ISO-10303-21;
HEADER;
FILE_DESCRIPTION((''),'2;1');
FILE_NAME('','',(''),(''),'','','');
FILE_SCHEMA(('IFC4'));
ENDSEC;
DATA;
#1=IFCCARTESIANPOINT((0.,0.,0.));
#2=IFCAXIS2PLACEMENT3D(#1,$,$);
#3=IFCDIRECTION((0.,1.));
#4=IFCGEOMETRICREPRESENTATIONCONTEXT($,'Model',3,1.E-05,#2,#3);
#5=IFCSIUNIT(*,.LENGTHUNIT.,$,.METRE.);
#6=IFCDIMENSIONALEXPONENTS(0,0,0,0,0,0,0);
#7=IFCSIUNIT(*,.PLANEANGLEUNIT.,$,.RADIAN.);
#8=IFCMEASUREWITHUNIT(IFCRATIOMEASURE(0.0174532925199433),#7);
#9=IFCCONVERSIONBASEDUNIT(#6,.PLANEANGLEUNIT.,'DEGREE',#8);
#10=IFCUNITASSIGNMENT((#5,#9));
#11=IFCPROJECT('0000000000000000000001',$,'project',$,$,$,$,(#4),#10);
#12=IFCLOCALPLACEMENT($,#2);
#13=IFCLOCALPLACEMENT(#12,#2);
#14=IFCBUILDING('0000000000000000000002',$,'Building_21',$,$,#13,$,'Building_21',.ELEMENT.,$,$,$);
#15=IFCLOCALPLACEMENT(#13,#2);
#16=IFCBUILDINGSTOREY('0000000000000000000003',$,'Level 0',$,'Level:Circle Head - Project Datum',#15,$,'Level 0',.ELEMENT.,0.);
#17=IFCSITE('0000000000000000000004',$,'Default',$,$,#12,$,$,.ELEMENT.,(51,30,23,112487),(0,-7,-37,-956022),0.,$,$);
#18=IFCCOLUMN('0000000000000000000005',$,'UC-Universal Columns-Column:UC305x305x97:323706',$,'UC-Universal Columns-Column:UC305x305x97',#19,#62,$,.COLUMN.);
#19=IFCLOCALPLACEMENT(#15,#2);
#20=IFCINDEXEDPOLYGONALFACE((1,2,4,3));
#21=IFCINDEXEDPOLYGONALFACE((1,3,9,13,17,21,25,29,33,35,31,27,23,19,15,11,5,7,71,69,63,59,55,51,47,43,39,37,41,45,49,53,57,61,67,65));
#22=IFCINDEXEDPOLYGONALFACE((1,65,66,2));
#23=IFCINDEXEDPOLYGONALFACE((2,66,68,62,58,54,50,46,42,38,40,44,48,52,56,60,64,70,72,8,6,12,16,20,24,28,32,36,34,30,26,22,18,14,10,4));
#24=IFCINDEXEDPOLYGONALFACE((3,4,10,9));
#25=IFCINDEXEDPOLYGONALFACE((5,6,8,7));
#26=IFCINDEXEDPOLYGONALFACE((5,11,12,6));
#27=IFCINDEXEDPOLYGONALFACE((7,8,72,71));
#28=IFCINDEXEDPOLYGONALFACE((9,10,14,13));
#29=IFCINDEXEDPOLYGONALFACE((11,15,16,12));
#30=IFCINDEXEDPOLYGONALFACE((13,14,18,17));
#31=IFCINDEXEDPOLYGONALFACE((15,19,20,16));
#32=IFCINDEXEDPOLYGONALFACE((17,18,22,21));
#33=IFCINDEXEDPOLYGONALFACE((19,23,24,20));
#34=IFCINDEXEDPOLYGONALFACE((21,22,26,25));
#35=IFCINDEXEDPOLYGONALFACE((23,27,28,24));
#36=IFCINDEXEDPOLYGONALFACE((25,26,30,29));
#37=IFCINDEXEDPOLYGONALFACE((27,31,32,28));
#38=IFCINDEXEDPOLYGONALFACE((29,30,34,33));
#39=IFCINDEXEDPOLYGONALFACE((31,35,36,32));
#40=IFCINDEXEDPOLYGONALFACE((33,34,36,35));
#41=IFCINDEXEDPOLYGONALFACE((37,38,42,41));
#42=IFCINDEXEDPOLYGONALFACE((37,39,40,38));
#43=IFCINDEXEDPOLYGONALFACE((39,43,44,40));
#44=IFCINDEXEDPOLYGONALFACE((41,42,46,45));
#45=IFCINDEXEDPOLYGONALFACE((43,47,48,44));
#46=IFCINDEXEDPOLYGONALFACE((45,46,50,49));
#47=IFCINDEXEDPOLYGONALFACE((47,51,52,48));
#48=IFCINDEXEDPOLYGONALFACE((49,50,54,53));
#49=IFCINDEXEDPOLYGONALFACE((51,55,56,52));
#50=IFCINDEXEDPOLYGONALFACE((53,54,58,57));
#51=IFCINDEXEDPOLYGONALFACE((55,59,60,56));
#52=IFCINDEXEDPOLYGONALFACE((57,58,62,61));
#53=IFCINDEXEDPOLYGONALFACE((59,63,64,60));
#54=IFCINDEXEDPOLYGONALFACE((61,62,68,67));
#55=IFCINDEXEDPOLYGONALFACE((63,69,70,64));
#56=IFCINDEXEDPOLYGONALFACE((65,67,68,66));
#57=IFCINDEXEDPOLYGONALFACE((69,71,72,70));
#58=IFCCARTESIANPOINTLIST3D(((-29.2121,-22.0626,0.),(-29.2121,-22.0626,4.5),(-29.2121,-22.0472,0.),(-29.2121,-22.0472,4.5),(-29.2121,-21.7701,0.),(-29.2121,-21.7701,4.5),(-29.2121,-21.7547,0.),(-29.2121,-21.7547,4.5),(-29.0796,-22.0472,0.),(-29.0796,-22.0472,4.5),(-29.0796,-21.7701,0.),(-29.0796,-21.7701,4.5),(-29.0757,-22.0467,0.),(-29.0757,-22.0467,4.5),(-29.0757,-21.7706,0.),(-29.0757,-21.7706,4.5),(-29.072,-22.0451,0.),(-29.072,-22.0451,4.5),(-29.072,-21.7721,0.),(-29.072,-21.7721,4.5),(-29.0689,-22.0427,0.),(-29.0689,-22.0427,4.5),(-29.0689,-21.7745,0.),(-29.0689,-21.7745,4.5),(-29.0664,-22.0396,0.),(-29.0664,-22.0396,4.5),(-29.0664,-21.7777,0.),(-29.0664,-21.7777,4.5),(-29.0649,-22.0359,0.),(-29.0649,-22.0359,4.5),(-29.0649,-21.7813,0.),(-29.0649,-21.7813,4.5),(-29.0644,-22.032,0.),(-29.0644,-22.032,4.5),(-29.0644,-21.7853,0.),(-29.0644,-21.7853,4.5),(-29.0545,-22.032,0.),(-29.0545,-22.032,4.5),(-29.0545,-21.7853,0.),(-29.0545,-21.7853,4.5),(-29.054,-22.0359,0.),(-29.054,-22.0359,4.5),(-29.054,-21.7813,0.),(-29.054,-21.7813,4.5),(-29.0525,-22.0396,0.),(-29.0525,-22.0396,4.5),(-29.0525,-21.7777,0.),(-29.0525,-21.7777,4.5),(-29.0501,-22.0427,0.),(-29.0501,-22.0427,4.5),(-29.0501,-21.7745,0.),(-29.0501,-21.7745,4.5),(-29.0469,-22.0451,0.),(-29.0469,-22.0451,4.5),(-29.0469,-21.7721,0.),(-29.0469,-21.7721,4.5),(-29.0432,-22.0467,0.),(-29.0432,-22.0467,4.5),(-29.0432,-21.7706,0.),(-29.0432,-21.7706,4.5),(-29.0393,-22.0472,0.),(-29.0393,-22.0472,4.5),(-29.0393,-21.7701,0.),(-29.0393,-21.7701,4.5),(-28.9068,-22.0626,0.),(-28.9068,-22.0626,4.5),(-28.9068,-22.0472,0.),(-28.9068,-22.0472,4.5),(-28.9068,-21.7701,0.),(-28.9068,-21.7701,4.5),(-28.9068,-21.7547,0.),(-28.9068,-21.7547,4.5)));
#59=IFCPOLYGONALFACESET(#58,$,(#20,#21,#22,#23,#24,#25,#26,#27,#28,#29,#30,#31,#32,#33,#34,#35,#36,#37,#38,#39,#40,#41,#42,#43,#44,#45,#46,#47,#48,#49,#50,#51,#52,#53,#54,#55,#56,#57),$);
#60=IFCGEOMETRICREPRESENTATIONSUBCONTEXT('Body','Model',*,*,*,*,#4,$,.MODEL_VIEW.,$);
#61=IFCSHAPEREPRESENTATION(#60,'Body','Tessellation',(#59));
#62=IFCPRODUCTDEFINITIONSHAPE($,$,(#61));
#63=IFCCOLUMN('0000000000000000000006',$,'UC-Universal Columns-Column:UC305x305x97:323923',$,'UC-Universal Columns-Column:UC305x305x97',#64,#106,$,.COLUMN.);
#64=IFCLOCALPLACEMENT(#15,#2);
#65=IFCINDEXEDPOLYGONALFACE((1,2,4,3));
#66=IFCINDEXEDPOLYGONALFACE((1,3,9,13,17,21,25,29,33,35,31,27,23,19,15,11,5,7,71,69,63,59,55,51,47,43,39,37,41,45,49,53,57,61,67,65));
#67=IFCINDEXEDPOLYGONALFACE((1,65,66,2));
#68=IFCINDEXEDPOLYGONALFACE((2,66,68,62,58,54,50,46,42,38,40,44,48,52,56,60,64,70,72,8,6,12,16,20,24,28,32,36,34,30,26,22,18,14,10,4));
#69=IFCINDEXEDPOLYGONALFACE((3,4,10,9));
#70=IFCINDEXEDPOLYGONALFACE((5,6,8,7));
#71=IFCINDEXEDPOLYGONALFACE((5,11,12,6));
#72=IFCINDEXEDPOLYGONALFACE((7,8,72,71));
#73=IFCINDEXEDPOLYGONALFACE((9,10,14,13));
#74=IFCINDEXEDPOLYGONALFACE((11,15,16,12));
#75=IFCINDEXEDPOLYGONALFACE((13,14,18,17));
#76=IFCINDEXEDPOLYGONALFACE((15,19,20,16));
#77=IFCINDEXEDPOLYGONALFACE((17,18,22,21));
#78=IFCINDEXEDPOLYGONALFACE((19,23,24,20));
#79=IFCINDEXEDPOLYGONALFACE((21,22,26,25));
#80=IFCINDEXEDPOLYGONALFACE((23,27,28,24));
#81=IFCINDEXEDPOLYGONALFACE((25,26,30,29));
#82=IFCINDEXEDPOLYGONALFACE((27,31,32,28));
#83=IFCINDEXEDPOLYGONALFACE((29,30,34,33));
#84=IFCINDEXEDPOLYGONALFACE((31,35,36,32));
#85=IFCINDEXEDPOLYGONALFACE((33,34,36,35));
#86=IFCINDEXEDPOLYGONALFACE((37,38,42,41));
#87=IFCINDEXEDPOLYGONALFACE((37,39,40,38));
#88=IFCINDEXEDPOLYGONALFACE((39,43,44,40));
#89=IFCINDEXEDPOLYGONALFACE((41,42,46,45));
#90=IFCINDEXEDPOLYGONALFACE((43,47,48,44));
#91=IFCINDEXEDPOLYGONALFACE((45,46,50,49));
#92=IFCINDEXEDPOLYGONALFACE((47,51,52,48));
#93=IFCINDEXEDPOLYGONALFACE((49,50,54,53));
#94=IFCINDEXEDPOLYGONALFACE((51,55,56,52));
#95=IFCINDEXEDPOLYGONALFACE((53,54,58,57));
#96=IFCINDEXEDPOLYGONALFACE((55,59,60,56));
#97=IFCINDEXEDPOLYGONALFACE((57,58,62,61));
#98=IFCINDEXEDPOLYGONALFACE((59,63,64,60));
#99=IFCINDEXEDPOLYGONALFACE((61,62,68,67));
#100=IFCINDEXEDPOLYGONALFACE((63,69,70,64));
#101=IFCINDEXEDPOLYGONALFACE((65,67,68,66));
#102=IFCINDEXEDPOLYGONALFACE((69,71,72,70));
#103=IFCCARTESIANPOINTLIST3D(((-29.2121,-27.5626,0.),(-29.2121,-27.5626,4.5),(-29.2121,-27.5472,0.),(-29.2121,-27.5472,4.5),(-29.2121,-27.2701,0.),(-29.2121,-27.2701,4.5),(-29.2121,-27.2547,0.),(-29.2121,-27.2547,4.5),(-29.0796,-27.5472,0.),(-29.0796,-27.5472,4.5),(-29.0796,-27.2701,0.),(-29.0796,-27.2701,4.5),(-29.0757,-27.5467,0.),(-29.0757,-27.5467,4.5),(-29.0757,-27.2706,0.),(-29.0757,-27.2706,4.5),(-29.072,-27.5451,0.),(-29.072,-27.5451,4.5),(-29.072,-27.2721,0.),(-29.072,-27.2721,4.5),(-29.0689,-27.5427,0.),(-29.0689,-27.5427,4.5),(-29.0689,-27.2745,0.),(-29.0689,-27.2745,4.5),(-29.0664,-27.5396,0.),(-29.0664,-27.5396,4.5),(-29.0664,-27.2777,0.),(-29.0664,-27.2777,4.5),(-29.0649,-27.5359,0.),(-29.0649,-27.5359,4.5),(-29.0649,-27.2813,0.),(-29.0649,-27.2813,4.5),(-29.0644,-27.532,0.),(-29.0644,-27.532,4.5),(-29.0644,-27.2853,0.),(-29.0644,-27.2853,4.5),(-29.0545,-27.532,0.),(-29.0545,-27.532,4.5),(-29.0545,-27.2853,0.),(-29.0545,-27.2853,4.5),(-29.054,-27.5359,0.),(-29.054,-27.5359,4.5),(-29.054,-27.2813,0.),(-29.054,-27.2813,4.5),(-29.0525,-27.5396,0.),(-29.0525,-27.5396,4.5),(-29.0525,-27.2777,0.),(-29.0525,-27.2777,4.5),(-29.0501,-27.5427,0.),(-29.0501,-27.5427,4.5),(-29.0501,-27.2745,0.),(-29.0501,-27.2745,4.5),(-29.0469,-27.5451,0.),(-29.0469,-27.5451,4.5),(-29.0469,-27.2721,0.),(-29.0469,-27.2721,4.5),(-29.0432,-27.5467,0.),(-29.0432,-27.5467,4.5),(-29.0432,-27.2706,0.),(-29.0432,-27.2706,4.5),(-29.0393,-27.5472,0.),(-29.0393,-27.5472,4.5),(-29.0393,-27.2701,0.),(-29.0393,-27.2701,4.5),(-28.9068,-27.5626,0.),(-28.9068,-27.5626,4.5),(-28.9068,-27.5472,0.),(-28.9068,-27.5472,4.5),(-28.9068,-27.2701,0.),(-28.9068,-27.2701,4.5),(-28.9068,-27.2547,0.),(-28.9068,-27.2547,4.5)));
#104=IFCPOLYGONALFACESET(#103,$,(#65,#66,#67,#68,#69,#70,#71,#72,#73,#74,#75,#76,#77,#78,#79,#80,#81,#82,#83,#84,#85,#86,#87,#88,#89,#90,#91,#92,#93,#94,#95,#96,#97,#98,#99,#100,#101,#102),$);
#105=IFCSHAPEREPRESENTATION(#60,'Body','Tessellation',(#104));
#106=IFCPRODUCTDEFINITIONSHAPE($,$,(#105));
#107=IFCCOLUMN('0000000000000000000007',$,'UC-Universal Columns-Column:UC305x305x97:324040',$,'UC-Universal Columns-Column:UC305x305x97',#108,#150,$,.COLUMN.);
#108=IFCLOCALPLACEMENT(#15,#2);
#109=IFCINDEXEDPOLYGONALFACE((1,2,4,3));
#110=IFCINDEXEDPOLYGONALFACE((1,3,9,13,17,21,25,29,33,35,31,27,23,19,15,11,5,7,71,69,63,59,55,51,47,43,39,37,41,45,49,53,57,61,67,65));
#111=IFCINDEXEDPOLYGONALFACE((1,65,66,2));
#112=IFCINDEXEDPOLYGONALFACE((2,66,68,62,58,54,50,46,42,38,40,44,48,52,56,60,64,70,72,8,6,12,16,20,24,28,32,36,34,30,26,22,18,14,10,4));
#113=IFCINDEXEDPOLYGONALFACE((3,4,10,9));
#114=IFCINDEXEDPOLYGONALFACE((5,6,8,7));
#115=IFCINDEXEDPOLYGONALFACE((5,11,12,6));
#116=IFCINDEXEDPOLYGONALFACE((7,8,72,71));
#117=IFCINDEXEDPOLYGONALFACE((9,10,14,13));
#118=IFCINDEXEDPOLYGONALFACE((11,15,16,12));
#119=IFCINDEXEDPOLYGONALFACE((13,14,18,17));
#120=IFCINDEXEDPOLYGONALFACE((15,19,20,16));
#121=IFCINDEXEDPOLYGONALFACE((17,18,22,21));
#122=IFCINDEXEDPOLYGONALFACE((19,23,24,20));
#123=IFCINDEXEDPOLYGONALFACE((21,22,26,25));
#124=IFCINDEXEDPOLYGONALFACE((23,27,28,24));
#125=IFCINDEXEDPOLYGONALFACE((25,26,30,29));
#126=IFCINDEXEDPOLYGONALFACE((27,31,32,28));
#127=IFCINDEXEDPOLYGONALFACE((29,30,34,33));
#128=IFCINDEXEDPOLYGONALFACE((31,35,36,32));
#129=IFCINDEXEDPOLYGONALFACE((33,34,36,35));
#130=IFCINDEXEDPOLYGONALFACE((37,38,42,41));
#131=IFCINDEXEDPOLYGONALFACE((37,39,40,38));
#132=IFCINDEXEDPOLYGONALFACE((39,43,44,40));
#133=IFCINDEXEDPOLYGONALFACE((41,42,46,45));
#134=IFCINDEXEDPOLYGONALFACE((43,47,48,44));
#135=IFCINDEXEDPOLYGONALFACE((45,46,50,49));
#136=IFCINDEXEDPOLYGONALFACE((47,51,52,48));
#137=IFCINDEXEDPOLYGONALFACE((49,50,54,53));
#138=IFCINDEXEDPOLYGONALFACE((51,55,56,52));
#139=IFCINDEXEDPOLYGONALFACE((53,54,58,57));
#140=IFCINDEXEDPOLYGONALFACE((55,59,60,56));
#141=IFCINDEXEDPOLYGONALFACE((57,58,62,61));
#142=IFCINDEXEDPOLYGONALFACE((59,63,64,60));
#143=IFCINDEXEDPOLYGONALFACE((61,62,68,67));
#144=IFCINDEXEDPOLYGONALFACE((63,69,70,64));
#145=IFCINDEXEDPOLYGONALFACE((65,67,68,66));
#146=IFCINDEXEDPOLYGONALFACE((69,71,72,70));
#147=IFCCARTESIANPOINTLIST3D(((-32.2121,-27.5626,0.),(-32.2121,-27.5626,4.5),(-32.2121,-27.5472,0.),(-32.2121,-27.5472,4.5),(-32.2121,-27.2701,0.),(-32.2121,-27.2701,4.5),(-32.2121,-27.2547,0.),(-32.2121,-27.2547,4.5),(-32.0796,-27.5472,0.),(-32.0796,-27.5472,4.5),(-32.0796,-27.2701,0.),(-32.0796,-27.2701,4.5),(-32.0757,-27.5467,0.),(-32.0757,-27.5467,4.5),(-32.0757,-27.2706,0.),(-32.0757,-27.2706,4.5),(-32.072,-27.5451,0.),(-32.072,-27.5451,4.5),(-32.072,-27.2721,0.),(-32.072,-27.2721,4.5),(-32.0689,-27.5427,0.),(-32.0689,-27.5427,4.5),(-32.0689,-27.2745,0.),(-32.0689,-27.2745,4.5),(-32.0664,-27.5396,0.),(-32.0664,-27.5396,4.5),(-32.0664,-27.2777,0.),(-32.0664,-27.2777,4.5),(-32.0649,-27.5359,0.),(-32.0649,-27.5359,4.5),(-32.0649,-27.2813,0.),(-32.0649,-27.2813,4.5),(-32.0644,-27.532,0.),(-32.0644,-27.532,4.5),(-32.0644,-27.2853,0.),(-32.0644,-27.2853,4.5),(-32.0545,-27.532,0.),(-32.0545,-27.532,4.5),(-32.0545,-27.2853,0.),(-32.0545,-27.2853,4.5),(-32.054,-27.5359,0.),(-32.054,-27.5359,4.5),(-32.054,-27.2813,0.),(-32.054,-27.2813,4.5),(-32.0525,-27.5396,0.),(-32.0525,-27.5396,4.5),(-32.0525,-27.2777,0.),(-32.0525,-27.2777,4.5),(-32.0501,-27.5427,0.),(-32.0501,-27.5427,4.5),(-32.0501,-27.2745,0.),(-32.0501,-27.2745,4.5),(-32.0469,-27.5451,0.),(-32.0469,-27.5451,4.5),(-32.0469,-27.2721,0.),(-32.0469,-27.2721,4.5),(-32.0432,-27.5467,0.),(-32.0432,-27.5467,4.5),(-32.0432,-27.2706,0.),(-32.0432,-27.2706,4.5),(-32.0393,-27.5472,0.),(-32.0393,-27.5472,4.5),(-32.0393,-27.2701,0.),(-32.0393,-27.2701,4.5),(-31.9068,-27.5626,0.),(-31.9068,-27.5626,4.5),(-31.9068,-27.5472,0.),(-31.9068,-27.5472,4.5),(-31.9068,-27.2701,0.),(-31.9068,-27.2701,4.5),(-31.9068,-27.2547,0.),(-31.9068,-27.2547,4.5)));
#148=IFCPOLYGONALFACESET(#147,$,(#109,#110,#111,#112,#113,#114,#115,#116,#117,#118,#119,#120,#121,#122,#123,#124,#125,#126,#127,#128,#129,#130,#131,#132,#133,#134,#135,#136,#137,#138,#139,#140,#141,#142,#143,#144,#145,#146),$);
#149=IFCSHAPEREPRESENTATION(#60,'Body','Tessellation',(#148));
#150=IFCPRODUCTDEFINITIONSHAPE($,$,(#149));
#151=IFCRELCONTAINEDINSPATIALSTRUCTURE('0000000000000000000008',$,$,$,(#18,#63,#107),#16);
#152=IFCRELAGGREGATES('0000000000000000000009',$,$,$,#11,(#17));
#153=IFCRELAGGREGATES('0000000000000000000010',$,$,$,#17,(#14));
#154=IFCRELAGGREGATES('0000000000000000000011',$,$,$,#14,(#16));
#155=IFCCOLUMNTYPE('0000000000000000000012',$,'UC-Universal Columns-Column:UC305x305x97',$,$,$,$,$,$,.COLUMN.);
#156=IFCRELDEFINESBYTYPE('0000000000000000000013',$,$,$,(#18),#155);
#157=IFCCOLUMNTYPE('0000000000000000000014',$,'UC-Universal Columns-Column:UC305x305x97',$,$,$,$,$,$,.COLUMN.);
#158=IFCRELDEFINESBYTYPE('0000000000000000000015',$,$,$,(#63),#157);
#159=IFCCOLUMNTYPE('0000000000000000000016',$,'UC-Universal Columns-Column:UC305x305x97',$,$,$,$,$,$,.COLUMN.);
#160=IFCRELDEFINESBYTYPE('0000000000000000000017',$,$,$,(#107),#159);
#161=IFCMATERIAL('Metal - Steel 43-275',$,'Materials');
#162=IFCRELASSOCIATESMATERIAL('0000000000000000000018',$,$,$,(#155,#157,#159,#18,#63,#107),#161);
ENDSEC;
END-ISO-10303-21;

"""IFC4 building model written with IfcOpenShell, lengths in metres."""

from ifc_helpers import new_model, entity, si_unit, converted_unit, direction, frame, frame_2d, origin, place, context, subcontext, project, spatial, polyline, circle_curve, parameter, trimmed, segment, composite_curve, i_section, outline, extrude, source, transform, mapped, material, material_profile, profile_set, profile_usage, type_object, type_shapes, element, save


model = new_model("IFC4")

# Units and contexts
model_context = context("Model", 3, precision=1e-05, world=origin(), true_north=direction((0.0, 1.0)))
body_context = subcontext(model_context, "Body", "Model", "MODEL_VIEW")
ifc_project = project(units=[si_unit("LENGTHUNIT", "METRE"), converted_unit("PLANEANGLEUNIT", "DEGREE", entity("IfcRatioMeasure", 0.0174532925199433), si_unit("PLANEANGLEUNIT", "RADIAN"), dimensions=[0, 0, 0, 0, 0, 0, 0])], contexts=[model_context])

# Site, building, storey
site_placement = place(None, origin())
site = spatial("IfcSite", under=ifc_project, at=site_placement, Name="Default", CompositionType="ELEMENT", RefLatitude=(51, 30, 23, 112487), RefLongitude=(0, -7, -37, -956022), RefElevation=0.0)
building_placement = place(site_placement, origin())
building = spatial("IfcBuilding", under=site, at=building_placement, Name="Building_21", LongName="Building_21", CompositionType="ELEMENT")
storey_placement = place(building_placement, origin())
storey = spatial("IfcBuildingStorey", under=building, at=storey_placement, Name="Level 0", ObjectType="Level:Circle Head - Project Datum", LongName="Level 0", CompositionType="ELEMENT", Elevation=0.0)

# Columns
ifc_material_1 = material(Name="Metal - Steel 43-275", Category="Materials")
ifc_material_profile_1 = material_profile(ifc_material_1, outline(composite_curve([segment(polyline([(-0.1527, 0.154, 0.0), (0.1527, 0.154, 0.0)]), True, "CONTINUOUS"), segment(polyline([(0.1527, 0.154, 0.0), (0.1527, 0.1386, 0.0)]), True, "CONTINUOUS"), segment(polyline([(0.1527, 0.1386, 0.0), (0.0201, 0.1386, 0.0)]), True, "CONTINUOUS"), segment(trimmed(circle_curve(frame((0.0201, 0.1234, 0.0)), 0.0152), [parameter(90.0)], [parameter(180.0)], True, "PARAMETER"), True, "CONTINUOUS"), segment(polyline([(0.0049, 0.1234, 0.0), (0.0049, -0.1234, 0.0)]), True, "CONTINUOUS"), segment(trimmed(circle_curve(frame((0.0201, -0.1234, 0.0)), 0.0152), [parameter(180.0)], [parameter(270.0)], True, "PARAMETER"), True, "CONTINUOUS"), segment(polyline([(0.0201, -0.1386, 0.0), (0.1527, -0.1386, 0.0)]), True, "CONTINUOUS"), segment(polyline([(0.1527, -0.1386, 0.0), (0.1527, -0.154, 0.0)]), True, "CONTINUOUS"), segment(polyline([(0.1527, -0.154, 0.0), (-0.1527, -0.154, 0.0)]), True, "CONTINUOUS"), segment(polyline([(-0.1527, -0.154, 0.0), (-0.1527, -0.1386, 0.0)]), True, "CONTINUOUS"), segment(polyline([(-0.1527, -0.1386, 0.0), (-0.0201, -0.1386, 0.0)]), True, "CONTINUOUS"), segment(trimmed(circle_curve(frame((-0.0201, -0.1234, 0.0)), 0.0152), [parameter(270.0)], [parameter(0.0)], True, "PARAMETER"), True, "CONTINUOUS"), segment(polyline([(-0.0049, -0.1234, 0.0), (-0.005, 0.1234, 0.0)]), True, "CONTINUOUS"), segment(trimmed(circle_curve(frame((-0.0201, 0.1234, 0.0)), 0.0152), [parameter(0.0)], [parameter(90.0)], True, "PARAMETER"), True, "CONTINUOUS"), segment(polyline([(-0.0201, 0.1386, 0.0), (-0.1527, 0.1386, 0.0)]), True, "CONTINUOUS"), segment(polyline([(-0.1527, 0.1386, 0.0), (-0.1527, 0.154, 0.0)]), True, "CONTINUOUS")], self_intersect=False), kind="CURVE"), Name="UC305x305x97")
ifc_material_profile_2 = material_profile(ifc_material_1, outline(composite_curve([segment(polyline([(0.1527, 0.154, 0.0), (0.1527, 0.1386, 0.0)]), True, "CONTINUOUS"), segment(polyline([(0.1527, 0.1386, 0.0), (0.0049, 0.1386, 0.0)]), True, "CONTINUOUS"), segment(polyline([(0.0049, 0.1386, 0.0), (0.0049, -0.1386, 0.0)]), True, "CONTINUOUS"), segment(polyline([(0.0049, -0.1386, 0.0), (0.1527, -0.1386, 0.0)]), True, "CONTINUOUS"), segment(polyline([(0.1527, -0.1386, 0.0), (0.1527, -0.154, 0.0)]), True, "CONTINUOUS"), segment(polyline([(0.1527, -0.154, 0.0), (-0.1527, -0.154, 0.0)]), True, "CONTINUOUS"), segment(polyline([(-0.1527, -0.154, 0.0), (-0.1527, -0.1386, 0.0)]), True, "CONTINUOUS"), segment(polyline([(-0.1527, -0.1386, 0.0), (-0.005, -0.1386, 0.0)]), True, "CONTINUOUS"), segment(polyline([(-0.005, -0.1386, 0.0), (-0.005, 0.1386, 0.0)]), True, "CONTINUOUS"), segment(polyline([(-0.005, 0.1386, 0.0), (-0.1527, 0.1386, 0.0)]), True, "CONTINUOUS"), segment(polyline([(-0.1527, 0.1386, 0.0), (-0.1527, 0.154, 0.0)]), True, "CONTINUOUS"), segment(polyline([(-0.1527, 0.154, 0.0), (0.1527, 0.154, 0.0)]), True, "CONTINUOUS")], self_intersect=False), kind="CURVE"), Name="UC305x305x97")
ifc_profile_set = profile_set([ifc_material_profile_1, ifc_material_profile_2], Name="UC305x305x97")
ifc_profile_usage_1 = profile_usage(ifc_profile_set)
column_type_1 = type_object("IfcColumnType", Name="UC-Universal Columns-Column:UC305x305x97", PredefinedType="COLUMN", material=ifc_profile_set)
shared_shape_1 = source(origin(), body_context, "Body", "SweptSolid", [
    extrude(i_section(OverallWidth=0.3053, OverallDepth=0.3079, WebThickness=0.0099, FlangeThickness=0.0154, FilletRadius=0.0152, at=frame_2d((0.0, 0.0), x_axis=(0.0, 1.0))), frame((-29.0595, -21.9086, 0.0), z_axis=(0.0, 0.0, 1.0), x_axis=(0.0, -1.0, 0.0)), (0.0, 0.0, 1.0), 4.5),
])
type_shapes(column_type_1, [shared_shape_1])
column_1_placement = place(storey_placement, origin())
element("IfcColumn", 1, at=column_1_placement, inside=storey, type_object=column_type_1, material=ifc_profile_usage_1, Name="UC-Universal Columns-Column:UC305x305x97:323706", ObjectType="UC-Universal Columns-Column:UC305x305x97", PredefinedType="COLUMN", context=body_context, shape_type="MappedRepresentation", body=[
    mapped(shared_shape_1, transform((0.0, 0.0, 0.0), scale=1.0)),
])
ifc_profile_usage_2 = profile_usage(ifc_profile_set)
column_type_2 = type_object("IfcColumnType", Name="UC-Universal Columns-Column:UC305x305x97", PredefinedType="COLUMN", material=ifc_profile_set)
shared_shape_2 = source(origin(), body_context, "Body", "SweptSolid", [
    extrude(i_section(OverallWidth=0.3053, OverallDepth=0.3079, WebThickness=0.0099, FlangeThickness=0.0154, FilletRadius=0.0152, at=frame_2d((0.0, 0.0), x_axis=(0.0, 1.0))), frame((-29.0595, -27.4086, 0.0), z_axis=(0.0, 0.0, 1.0), x_axis=(0.0, -1.0, 0.0)), (0.0, 0.0, 1.0), 4.5),
])
type_shapes(column_type_2, [shared_shape_2])
column_2_placement = place(storey_placement, origin())
element("IfcColumn", 2, at=column_2_placement, inside=storey, type_object=column_type_2, material=ifc_profile_usage_2, Name="UC-Universal Columns-Column:UC305x305x97:323923", ObjectType="UC-Universal Columns-Column:UC305x305x97", PredefinedType="COLUMN", context=body_context, shape_type="MappedRepresentation", body=[
    mapped(shared_shape_2, transform((0.0, 0.0, 0.0), scale=1.0)),
])
ifc_profile_usage_3 = profile_usage(ifc_profile_set)
column_type_3 = type_object("IfcColumnType", Name="UC-Universal Columns-Column:UC305x305x97", PredefinedType="COLUMN", material=ifc_profile_set)
shared_shape_3 = source(origin(), body_context, "Body", "SweptSolid", [
    extrude(i_section(OverallWidth=0.3053, OverallDepth=0.3079, WebThickness=0.0099, FlangeThickness=0.0154, FilletRadius=0.0152, at=frame_2d((0.0, 0.0), x_axis=(0.0, 1.0))), frame((-32.0595, -27.4086, 0.0), z_axis=(0.0, 0.0, 1.0), x_axis=(0.0, -1.0, 0.0)), (0.0, 0.0, 1.0), 4.5),
])
type_shapes(column_type_3, [shared_shape_3])
column_3_placement = place(storey_placement, origin())
element("IfcColumn", 3, at=column_3_placement, inside=storey, type_object=column_type_3, material=ifc_profile_usage_3, Name="UC-Universal Columns-Column:UC305x305x97:324040", ObjectType="UC-Universal Columns-Column:UC305x305x97", PredefinedType="COLUMN", context=body_context, shape_type="MappedRepresentation", body=[
    mapped(shared_shape_3, transform((0.0, 0.0, 0.0), scale=1.0)),
])

save(model, "model.ifc")
